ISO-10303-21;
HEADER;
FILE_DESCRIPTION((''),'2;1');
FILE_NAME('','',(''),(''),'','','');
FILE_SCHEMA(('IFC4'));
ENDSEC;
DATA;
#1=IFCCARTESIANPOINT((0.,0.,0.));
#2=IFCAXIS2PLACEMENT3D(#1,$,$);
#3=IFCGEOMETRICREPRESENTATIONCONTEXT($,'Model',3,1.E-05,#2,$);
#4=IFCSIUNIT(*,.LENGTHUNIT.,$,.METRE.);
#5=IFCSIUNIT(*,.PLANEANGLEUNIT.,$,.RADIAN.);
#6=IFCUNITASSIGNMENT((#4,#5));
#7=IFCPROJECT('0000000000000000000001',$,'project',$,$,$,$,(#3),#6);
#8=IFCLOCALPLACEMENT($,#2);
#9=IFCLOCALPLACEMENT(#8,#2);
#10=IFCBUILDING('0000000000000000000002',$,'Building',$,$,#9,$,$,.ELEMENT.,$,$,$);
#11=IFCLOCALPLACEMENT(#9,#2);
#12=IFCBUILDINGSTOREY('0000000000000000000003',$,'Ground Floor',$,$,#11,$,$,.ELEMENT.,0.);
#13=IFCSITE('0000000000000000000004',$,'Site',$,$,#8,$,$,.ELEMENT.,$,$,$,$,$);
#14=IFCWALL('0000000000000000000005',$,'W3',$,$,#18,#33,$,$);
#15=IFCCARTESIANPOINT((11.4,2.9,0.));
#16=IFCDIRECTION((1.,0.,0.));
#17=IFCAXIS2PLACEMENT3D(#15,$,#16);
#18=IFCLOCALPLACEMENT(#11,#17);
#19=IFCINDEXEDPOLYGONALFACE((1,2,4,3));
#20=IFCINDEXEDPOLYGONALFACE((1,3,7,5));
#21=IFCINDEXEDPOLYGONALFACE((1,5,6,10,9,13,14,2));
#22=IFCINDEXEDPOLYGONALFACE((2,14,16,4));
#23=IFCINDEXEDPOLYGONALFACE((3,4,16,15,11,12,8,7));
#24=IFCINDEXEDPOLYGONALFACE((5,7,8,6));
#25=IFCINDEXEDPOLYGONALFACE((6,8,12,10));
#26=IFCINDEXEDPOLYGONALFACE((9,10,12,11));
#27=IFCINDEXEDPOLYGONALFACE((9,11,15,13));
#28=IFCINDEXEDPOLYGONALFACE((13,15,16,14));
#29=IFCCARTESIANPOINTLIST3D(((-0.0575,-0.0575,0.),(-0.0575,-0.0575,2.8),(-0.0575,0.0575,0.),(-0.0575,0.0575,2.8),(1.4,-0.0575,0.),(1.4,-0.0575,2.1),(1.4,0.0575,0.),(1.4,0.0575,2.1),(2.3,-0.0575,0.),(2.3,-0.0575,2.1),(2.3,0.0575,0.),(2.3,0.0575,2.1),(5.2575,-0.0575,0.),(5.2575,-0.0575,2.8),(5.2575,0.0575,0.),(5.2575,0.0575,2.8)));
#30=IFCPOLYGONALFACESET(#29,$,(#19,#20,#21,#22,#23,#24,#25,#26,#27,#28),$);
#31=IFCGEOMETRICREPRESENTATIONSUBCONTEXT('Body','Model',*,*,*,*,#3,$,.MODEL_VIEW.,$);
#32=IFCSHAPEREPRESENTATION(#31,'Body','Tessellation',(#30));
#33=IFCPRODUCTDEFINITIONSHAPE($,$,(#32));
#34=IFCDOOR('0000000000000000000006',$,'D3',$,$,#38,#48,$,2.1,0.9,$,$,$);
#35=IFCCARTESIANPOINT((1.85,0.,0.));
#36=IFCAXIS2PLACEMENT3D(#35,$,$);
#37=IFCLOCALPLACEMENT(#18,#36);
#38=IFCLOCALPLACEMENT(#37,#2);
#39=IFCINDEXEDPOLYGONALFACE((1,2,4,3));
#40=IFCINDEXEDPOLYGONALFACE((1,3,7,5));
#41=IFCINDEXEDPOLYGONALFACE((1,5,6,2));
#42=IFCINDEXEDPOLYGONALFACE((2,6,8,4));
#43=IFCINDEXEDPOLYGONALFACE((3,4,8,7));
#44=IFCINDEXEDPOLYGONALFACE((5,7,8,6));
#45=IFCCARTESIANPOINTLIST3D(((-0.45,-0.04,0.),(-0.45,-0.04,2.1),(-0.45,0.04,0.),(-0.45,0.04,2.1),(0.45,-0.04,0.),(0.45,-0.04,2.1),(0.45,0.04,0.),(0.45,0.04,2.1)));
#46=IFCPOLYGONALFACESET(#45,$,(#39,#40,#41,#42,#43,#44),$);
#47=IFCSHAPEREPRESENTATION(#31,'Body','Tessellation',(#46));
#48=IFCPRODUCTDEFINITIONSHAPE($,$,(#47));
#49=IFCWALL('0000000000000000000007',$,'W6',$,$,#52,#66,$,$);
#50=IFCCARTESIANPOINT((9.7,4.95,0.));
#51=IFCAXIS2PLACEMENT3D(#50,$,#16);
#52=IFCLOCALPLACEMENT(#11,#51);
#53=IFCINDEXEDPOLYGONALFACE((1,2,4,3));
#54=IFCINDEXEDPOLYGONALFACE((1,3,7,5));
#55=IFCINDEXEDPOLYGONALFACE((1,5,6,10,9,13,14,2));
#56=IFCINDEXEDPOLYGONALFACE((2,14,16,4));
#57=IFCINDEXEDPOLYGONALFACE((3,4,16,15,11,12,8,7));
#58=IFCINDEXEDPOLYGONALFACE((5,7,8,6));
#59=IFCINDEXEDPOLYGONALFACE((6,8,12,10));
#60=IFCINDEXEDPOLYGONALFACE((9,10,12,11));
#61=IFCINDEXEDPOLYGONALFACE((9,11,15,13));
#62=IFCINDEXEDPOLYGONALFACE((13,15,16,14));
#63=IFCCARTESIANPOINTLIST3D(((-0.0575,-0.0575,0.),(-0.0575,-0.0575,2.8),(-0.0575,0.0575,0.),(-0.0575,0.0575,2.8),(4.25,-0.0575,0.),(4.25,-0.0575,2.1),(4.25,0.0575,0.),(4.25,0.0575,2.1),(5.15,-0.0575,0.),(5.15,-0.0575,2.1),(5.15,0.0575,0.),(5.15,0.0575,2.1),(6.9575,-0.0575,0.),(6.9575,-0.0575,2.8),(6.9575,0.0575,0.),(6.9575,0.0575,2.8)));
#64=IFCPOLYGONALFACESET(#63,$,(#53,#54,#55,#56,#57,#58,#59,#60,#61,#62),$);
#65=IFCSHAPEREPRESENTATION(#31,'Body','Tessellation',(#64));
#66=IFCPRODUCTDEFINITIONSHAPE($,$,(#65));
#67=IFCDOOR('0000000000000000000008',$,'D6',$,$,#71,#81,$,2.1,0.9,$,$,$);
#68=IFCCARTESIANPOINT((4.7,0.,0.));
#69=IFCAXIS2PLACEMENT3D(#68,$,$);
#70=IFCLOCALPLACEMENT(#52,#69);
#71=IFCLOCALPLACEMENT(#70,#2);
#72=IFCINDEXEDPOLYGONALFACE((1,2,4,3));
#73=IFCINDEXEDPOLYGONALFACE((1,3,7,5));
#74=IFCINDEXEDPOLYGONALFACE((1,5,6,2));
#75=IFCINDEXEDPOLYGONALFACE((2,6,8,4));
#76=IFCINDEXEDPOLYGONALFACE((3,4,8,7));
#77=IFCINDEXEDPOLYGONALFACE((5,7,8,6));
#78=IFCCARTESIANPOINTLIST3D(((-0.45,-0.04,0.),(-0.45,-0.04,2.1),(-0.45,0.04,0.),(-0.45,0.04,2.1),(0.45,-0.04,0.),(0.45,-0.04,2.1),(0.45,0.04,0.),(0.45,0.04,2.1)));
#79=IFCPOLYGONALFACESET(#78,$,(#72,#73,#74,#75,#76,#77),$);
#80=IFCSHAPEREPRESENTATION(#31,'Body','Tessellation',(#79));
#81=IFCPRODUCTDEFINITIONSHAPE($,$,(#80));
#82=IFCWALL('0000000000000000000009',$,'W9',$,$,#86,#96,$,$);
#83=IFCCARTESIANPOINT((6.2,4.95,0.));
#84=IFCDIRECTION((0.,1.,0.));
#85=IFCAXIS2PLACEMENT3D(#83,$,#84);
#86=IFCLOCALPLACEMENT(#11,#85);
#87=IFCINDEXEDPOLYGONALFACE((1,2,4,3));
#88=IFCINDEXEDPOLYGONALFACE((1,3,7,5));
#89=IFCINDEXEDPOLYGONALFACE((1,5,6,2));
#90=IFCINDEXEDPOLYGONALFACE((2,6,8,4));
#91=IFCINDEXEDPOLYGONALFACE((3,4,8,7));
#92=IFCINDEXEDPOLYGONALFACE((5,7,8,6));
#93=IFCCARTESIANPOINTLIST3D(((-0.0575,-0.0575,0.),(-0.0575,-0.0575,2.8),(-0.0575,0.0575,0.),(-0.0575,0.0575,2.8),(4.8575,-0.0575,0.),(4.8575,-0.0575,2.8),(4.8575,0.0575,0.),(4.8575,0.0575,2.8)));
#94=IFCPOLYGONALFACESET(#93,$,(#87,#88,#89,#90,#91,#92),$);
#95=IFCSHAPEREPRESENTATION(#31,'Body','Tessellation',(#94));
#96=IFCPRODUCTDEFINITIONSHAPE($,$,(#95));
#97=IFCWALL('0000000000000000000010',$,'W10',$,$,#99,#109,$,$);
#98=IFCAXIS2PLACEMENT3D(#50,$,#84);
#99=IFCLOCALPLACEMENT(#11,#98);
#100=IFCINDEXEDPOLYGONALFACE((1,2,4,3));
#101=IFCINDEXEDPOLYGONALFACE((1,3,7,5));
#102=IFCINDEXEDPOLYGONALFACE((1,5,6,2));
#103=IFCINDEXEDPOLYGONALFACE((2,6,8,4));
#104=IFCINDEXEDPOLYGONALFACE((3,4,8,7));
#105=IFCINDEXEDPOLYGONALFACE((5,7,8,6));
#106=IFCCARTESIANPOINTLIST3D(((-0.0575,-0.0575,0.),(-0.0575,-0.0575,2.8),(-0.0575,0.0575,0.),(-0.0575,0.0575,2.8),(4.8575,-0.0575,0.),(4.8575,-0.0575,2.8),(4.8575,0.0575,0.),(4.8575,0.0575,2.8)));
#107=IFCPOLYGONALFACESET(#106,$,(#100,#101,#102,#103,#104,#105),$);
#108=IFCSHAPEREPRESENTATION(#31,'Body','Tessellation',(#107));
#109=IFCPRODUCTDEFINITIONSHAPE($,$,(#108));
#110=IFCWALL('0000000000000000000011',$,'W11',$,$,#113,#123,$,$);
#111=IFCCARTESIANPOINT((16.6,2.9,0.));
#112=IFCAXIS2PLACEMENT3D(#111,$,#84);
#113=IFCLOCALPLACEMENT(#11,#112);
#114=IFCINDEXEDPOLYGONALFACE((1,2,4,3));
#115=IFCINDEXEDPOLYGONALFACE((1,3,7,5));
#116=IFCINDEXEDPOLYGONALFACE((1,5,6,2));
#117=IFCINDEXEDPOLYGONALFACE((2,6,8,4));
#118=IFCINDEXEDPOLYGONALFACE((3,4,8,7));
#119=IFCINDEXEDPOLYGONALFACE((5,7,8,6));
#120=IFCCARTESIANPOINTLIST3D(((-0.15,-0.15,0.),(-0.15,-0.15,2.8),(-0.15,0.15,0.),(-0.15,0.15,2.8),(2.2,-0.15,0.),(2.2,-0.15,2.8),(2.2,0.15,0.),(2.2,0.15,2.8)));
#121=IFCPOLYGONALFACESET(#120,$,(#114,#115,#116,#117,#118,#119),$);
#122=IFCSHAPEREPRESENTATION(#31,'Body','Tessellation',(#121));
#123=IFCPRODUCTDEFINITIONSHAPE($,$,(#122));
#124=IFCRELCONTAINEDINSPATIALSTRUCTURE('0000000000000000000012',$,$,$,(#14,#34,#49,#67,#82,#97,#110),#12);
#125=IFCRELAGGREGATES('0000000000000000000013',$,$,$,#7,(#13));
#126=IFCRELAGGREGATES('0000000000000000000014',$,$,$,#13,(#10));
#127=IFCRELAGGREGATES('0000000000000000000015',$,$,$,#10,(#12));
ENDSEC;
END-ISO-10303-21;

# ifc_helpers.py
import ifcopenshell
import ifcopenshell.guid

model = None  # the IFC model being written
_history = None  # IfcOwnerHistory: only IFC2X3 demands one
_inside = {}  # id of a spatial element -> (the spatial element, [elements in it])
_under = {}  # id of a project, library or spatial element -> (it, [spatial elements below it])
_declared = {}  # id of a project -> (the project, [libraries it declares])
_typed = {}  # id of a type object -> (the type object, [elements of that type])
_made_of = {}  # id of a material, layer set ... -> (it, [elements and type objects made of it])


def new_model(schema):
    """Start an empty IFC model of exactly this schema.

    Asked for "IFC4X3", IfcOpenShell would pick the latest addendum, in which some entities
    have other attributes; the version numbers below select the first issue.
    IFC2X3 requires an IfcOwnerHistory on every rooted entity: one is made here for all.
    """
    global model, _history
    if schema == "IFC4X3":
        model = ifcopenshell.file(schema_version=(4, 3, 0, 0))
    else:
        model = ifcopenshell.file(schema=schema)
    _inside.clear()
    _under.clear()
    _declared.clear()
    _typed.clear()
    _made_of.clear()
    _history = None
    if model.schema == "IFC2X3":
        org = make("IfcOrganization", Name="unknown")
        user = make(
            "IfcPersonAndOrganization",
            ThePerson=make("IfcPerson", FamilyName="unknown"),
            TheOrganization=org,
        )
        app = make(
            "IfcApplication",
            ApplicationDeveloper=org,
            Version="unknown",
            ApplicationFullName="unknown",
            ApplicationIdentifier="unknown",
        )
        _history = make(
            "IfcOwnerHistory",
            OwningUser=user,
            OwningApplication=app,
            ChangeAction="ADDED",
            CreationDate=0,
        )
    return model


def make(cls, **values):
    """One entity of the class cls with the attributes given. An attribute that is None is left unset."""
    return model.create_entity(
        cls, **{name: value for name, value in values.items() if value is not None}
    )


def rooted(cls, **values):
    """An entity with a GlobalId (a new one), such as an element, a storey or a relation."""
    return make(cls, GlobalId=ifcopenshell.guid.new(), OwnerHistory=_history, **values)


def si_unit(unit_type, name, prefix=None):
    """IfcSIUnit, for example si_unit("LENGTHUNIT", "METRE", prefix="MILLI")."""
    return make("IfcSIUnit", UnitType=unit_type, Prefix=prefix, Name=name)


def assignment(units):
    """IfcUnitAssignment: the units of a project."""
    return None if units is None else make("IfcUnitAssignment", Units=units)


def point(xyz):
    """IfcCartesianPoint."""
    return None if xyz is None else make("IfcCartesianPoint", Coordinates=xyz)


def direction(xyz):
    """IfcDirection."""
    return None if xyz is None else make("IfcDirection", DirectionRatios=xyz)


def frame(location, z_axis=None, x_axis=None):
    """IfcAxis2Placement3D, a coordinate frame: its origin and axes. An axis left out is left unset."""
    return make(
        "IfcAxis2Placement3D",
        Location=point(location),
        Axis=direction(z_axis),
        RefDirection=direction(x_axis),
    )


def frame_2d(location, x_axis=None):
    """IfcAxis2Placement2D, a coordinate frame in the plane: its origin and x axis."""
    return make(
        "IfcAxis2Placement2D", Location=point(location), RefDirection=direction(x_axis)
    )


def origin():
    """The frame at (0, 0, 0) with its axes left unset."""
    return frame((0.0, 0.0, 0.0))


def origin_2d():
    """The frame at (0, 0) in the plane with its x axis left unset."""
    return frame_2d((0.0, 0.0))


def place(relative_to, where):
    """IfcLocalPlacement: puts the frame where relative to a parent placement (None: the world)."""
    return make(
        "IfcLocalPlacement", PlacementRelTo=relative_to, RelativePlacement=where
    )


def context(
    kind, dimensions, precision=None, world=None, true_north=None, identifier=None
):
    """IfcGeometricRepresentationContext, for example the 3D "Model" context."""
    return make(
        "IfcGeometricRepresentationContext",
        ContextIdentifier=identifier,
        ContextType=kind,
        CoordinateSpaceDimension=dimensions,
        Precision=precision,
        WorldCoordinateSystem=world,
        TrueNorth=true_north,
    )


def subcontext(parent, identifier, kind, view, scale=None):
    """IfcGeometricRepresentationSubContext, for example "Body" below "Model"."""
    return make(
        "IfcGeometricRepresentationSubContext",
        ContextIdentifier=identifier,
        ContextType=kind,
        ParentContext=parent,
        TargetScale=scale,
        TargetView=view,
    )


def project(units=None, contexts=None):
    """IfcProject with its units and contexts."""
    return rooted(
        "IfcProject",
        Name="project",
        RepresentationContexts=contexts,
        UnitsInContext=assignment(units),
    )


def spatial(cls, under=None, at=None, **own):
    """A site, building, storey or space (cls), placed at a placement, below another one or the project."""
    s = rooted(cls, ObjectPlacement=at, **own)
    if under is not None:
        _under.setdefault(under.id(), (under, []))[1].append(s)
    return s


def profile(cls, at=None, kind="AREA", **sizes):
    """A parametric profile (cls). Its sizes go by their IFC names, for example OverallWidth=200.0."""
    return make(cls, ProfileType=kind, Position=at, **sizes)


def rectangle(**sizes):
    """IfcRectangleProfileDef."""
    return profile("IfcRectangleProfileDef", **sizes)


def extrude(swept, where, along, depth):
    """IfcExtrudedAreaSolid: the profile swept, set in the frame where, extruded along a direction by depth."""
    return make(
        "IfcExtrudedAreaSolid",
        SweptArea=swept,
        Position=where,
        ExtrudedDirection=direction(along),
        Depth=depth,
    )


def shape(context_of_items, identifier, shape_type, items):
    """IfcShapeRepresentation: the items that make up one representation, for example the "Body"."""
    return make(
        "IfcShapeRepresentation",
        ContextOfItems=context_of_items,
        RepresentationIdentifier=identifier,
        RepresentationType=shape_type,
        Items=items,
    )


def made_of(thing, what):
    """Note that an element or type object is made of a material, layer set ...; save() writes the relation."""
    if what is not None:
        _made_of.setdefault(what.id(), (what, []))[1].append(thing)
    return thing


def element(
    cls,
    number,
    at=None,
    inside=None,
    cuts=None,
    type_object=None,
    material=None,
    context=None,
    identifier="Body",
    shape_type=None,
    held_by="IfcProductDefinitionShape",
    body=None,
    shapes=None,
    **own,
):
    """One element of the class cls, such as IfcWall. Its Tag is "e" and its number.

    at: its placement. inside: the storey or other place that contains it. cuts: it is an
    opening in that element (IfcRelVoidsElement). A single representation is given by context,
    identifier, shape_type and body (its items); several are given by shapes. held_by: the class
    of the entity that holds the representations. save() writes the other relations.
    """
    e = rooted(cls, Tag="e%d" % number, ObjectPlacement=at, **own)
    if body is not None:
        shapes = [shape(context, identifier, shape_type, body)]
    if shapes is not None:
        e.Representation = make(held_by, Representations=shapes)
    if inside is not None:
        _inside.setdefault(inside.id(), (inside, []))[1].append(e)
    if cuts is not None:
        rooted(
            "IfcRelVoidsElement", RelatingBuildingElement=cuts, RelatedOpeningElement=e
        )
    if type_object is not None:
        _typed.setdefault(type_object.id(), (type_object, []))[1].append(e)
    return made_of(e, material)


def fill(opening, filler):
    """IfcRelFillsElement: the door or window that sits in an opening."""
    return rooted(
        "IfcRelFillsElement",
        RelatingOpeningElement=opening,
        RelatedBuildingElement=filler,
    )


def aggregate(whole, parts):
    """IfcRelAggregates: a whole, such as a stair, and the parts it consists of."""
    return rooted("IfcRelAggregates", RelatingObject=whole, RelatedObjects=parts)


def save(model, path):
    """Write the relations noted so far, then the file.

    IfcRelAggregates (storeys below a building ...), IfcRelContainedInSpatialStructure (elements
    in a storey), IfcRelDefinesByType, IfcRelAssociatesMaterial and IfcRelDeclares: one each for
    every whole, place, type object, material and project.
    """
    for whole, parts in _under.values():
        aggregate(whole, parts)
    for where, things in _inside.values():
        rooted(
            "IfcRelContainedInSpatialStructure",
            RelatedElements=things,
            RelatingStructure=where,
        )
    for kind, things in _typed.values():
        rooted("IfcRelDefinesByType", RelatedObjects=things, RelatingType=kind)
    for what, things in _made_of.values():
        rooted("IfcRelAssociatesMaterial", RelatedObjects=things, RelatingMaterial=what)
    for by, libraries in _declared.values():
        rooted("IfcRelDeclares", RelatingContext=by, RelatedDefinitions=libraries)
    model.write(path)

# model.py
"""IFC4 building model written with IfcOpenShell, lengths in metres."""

from ifc_helpers import new_model, si_unit, frame, frame_2d, origin, origin_2d, place, context, subcontext, project, spatial, rectangle, extrude, element, fill, save


model = new_model("IFC4")

# Units and contexts
model_context = context("Model", 3, precision=1e-05, world=origin())
body_context = subcontext(model_context, "Body", "Model", "MODEL_VIEW")
ifc_project = project(units=[si_unit("LENGTHUNIT", "METRE"), si_unit("PLANEANGLEUNIT", "RADIAN")], contexts=[model_context])

# Site, building, storey
site_placement = place(None, origin())
site = spatial("IfcSite", under=ifc_project, at=site_placement, Name="Site", CompositionType="ELEMENT")
building_placement = place(site_placement, origin())
building = spatial("IfcBuilding", under=site, at=building_placement, Name="Building", CompositionType="ELEMENT")
storey_placement = place(building_placement, origin())
storey = spatial("IfcBuildingStorey", under=building, at=storey_placement, Name="Ground Floor", CompositionType="ELEMENT", Elevation=0.0)

# Walls, openings, doors
wall_1_placement = place(storey_placement, frame((11.4, 2.9, 0.0), x_axis=(1.0, 0.0, 0.0)))
wall_1 = element("IfcWall", 1, at=wall_1_placement, inside=storey, Name="W3", context=body_context, shape_type="SweptSolid", body=[
    extrude(rectangle(XDim=5.315, YDim=0.115, at=frame_2d((2.6, 0.0))), origin(), (0.0, 0.0, 1.0), 2.8),
])
opening_1_placement = place(wall_1_placement, frame((1.85, 0.0, 0.0)))
opening_1 = element("IfcOpeningElement", 2, at=opening_1_placement, cuts=wall_1, context=body_context, shape_type="SweptSolid", body=[
    extrude(rectangle(XDim=0.9, YDim=0.215, at=origin_2d()), origin(), (0.0, 0.0, 1.0), 2.1),
])
door_1_placement = place(opening_1_placement, origin())
door_1 = element("IfcDoor", 3, at=door_1_placement, inside=storey, Name="D3", OverallHeight=2.1, OverallWidth=0.9, context=body_context, shape_type="SweptSolid", body=[
    extrude(rectangle(XDim=0.9, YDim=0.08, at=origin_2d()), origin(), (0.0, 0.0, 1.0), 2.1),
])
fill(opening_1, door_1)
wall_2_placement = place(storey_placement, frame((9.7, 4.95, 0.0), x_axis=(1.0, 0.0, 0.0)))
wall_2 = element("IfcWall", 4, at=wall_2_placement, inside=storey, Name="W6", context=body_context, shape_type="SweptSolid", body=[
    extrude(rectangle(XDim=7.015, YDim=0.115, at=frame_2d((3.45, 0.0))), origin(), (0.0, 0.0, 1.0), 2.8),
])
opening_2_placement = place(wall_2_placement, frame((4.7, 0.0, 0.0)))
opening_2 = element("IfcOpeningElement", 5, at=opening_2_placement, cuts=wall_2, context=body_context, shape_type="SweptSolid", body=[
    extrude(rectangle(XDim=0.9, YDim=0.215, at=origin_2d()), origin(), (0.0, 0.0, 1.0), 2.1),
])
door_2_placement = place(opening_2_placement, origin())
door_2 = element("IfcDoor", 6, at=door_2_placement, inside=storey, Name="D6", OverallHeight=2.1, OverallWidth=0.9, context=body_context, shape_type="SweptSolid", body=[
    extrude(rectangle(XDim=0.9, YDim=0.08, at=origin_2d()), origin(), (0.0, 0.0, 1.0), 2.1),
])
fill(opening_2, door_2)

# Walls
for number, where, x_axis, name in (
    (7, (6.2, 4.95, 0.0), (0.0, 1.0, 0.0), "W9"),
    (8, (9.7, 4.95, 0.0), (0.0, 1.0, 0.0), "W10"),
):
    element("IfcWall", number, at=place(storey_placement, frame(where, x_axis=x_axis)), inside=storey, Name=name, context=body_context, shape_type="SweptSolid", body=[
        extrude(rectangle(XDim=4.915, YDim=0.115, at=frame_2d((2.4, 0.0))), origin(), (0.0, 0.0, 1.0), 2.8),
    ])
wall_3_placement = place(storey_placement, frame((16.6, 2.9, 0.0), x_axis=(0.0, 1.0, 0.0)))
element("IfcWall", 9, at=wall_3_placement, inside=storey, Name="W11", context=body_context, shape_type="SweptSolid", body=[
    extrude(rectangle(XDim=2.35, YDim=0.3, at=frame_2d((1.025, 0.0))), origin(), (0.0, 0.0, 1.0), 2.8),
])

save(model, "model.ifc")
